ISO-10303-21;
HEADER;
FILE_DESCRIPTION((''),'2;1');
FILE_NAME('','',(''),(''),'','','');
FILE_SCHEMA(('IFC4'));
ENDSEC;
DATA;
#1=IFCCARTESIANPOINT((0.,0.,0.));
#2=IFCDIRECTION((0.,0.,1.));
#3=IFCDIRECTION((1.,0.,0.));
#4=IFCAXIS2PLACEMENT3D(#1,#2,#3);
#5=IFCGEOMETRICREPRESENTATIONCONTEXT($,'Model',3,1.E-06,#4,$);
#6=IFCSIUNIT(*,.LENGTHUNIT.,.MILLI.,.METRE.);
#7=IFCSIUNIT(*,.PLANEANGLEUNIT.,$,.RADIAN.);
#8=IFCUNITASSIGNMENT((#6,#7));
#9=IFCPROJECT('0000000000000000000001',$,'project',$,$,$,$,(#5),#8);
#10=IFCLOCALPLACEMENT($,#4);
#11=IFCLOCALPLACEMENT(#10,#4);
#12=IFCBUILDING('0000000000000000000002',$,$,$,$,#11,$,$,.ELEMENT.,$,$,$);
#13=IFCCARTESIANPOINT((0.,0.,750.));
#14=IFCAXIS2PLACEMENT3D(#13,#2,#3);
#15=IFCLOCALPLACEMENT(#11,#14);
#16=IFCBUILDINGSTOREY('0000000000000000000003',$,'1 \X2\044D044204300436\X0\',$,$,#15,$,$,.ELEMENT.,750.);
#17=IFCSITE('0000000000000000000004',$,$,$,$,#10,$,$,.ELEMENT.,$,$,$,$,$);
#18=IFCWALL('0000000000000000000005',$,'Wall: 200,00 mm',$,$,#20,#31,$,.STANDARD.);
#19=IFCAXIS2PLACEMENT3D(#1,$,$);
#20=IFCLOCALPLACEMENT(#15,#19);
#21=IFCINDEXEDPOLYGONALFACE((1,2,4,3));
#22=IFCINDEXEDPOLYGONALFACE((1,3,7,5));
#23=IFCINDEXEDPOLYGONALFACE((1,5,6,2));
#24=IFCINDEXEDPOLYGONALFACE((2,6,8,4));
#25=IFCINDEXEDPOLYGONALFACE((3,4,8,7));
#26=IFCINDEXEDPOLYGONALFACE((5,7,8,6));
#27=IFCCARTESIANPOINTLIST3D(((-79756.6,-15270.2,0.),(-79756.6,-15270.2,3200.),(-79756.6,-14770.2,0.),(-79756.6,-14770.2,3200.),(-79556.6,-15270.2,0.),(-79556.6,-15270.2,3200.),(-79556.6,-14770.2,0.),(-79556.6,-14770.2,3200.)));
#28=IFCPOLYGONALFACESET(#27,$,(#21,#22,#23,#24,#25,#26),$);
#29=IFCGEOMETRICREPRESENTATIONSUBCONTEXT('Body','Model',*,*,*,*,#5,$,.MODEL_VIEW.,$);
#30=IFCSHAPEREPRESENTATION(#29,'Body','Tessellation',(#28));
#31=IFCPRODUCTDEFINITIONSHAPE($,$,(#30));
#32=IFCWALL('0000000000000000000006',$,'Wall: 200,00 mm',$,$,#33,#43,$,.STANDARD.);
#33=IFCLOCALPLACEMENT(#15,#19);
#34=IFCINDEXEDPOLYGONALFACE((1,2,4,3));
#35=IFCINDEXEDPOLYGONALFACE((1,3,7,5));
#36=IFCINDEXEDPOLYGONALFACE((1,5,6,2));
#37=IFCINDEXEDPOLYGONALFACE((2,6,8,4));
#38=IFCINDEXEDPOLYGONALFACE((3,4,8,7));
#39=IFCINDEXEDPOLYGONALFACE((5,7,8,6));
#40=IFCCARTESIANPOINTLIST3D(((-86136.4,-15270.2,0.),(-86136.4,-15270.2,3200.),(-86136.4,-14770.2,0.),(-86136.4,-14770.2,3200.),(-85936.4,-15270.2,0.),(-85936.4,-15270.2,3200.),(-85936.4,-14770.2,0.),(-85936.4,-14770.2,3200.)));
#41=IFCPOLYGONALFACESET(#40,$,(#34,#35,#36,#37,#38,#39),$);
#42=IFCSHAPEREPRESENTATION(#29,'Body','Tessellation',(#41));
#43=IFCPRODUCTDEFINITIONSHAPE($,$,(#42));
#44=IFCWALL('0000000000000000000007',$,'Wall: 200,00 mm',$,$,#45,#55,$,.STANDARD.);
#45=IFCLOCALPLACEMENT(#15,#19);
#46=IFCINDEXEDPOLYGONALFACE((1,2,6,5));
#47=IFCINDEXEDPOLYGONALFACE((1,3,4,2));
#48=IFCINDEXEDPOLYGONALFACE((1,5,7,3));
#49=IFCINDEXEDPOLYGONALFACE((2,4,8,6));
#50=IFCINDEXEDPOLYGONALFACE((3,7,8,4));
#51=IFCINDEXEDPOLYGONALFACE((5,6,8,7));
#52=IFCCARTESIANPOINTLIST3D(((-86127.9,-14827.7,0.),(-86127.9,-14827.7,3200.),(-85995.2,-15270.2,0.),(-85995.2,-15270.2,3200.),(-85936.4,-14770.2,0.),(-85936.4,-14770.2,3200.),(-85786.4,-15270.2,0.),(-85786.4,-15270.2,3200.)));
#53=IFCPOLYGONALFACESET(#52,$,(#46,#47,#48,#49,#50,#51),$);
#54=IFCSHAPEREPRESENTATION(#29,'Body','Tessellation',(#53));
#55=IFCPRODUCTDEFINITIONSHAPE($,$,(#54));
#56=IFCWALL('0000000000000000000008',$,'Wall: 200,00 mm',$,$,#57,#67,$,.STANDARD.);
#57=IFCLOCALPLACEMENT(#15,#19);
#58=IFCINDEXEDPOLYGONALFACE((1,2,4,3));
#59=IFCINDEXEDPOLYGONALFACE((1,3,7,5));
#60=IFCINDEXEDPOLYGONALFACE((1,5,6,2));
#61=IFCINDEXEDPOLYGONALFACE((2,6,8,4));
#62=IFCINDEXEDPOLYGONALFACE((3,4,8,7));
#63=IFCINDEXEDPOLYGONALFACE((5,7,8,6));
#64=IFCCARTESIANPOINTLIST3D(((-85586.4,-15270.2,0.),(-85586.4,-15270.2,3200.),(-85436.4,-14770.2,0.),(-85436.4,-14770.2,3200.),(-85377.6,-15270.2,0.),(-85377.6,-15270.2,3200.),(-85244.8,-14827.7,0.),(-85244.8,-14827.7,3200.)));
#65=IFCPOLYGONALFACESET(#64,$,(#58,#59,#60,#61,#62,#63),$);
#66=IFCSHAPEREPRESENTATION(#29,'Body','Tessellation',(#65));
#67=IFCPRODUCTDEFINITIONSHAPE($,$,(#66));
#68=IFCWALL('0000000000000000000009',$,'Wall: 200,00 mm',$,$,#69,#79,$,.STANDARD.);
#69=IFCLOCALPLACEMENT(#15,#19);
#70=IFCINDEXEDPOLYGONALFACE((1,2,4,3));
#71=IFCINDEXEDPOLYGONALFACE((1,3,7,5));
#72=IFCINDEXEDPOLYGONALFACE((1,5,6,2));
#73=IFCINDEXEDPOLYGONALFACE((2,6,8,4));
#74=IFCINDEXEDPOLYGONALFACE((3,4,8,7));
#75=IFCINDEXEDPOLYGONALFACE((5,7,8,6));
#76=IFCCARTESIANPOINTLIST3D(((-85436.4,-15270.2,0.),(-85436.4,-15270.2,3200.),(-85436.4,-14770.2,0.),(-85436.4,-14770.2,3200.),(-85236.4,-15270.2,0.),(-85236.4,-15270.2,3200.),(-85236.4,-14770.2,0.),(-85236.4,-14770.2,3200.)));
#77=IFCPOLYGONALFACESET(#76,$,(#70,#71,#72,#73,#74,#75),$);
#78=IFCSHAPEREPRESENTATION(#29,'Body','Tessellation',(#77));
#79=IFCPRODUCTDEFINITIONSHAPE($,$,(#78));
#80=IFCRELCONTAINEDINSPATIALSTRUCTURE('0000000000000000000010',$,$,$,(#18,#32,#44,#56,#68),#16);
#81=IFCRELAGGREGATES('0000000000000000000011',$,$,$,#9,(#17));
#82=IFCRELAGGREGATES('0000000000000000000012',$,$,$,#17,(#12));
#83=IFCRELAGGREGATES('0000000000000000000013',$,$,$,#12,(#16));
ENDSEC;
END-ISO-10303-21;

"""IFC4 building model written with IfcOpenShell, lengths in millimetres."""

from ifc_helpers import new_model, si_unit, frame, origin_with_axes, place, context, subcontext, project, spatial, line, indexed_curve, outline, extrude, element, save


model = new_model("IFC4")

# Units and contexts
model_context = context("Model", 3, precision=1e-06, world=origin_with_axes())
body_context = subcontext(model_context, "Body", "Model", "MODEL_VIEW")
ifc_project = project(units=[si_unit("LENGTHUNIT", "METRE", prefix="MILLI"), si_unit("PLANEANGLEUNIT", "RADIAN")], contexts=[model_context])

# Site, building, storey
site_placement = place(None, origin_with_axes())
site = spatial("IfcSite", under=ifc_project, at=site_placement, CompositionType="ELEMENT")
building_placement = place(site_placement, origin_with_axes())
building = spatial("IfcBuilding", under=site, at=building_placement, CompositionType="ELEMENT")
storey_placement = place(building_placement, frame((0.0, 0.0, 750.0), z_axis=(0.0, 0.0, 1.0), x_axis=(1.0, 0.0, 0.0)))
storey = spatial("IfcBuildingStorey", under=building, at=storey_placement, Name="1 этаж", CompositionType="ELEMENT", Elevation=750.0)

# Walls
wall_1_placement = place(storey_placement, frame((-79556.6, -14770.2, 0.0), z_axis=(0.0, 0.0, 1.0), x_axis=(0.0, -1.0, 0.0)))
element("IfcWall", 1, at=wall_1_placement, inside=storey, Name="Wall: 200,00 mm", PredefinedType="STANDARD", context=body_context, shape_type="SweptSolid", body=[
    extrude(outline(indexed_curve([(0.0, -200.0), (500.0, -200.0), (500.0, 0.0), (0.0, 0.0)], segments=[line(1, 2), line(2, 3), line(3, 4), line(4, 1)])), origin_with_axes(), (0.0, 0.0, 1.0), 3200.0),
])
wall_2_placement = place(storey_placement, frame((-86136.4, -14770.2, 0.0), z_axis=(0.0, 0.0, 1.0), x_axis=(0.0, -1.0, 0.0)))
element("IfcWall", 2, at=wall_2_placement, inside=storey, Name="Wall: 200,00 mm", PredefinedType="STANDARD", context=body_context, shape_type="SweptSolid", body=[
    extrude(outline(indexed_curve([(0.0, 0.0), (500.0, 0.0), (500.0, 200.0), (0.0, 200.0)], segments=[line(1, 2), line(2, 3), line(3, 4), line(4, 1)])), origin_with_axes(), (0.0, 0.0, 1.0), 3200.0),
])
wall_3_placement = place(storey_placement, frame((-85936.4, -14770.2, 0.0), z_axis=(0.0, 0.0, 1.0), x_axis=(0.287348, -0.957826, 0.0)))
element("IfcWall", 3, at=wall_3_placement, inside=storey, Name="Wall: 200,00 mm", PredefinedType="STANDARD", context=body_context, shape_type="SweptSolid", body=[
    extrude(outline(indexed_curve([(0.0, -200.0), (462.0, -200.0), (522.0, 0.0), (0.0, 0.0)], segments=[line(1, 2), line(2, 3), line(3, 4), line(4, 1)])), origin_with_axes(), (0.0, 0.0, 1.0), 3200.0),
])
wall_4_placement = place(storey_placement, frame((-85436.4, -14770.2, 0.0), z_axis=(0.0, 0.0, 1.0), x_axis=(-0.287348, -0.957826, 0.0)))
element("IfcWall", 4, at=wall_4_placement, inside=storey, Name="Wall: 200,00 mm", PredefinedType="STANDARD", context=body_context, shape_type="SweptSolid", body=[
    extrude(outline(indexed_curve([(0.0, 0.0), (522.0, 0.0), (462.0, 200.0), (0.0, 200.0)], segments=[line(1, 2), line(2, 3), line(3, 4), line(4, 1)])), origin_with_axes(), (0.0, 0.0, 1.0), 3200.0),
])
wall_5_placement = place(storey_placement, frame((-85236.4, -14770.2, 0.0), z_axis=(0.0, 0.0, 1.0), x_axis=(0.0, -1.0, 0.0)))
element("IfcWall", 5, at=wall_5_placement, inside=storey, Name="Wall: 200,00 mm", PredefinedType="STANDARD", context=body_context, shape_type="SweptSolid", body=[
    extrude(outline(indexed_curve([(0.0, -200.0), (500.0, -200.0), (500.0, 0.0), (0.0, 0.0)], segments=[line(1, 2), line(2, 3), line(3, 4), line(4, 1)])), origin_with_axes(), (0.0, 0.0, 1.0), 3200.0),
])

save(model, "model.ifc")
